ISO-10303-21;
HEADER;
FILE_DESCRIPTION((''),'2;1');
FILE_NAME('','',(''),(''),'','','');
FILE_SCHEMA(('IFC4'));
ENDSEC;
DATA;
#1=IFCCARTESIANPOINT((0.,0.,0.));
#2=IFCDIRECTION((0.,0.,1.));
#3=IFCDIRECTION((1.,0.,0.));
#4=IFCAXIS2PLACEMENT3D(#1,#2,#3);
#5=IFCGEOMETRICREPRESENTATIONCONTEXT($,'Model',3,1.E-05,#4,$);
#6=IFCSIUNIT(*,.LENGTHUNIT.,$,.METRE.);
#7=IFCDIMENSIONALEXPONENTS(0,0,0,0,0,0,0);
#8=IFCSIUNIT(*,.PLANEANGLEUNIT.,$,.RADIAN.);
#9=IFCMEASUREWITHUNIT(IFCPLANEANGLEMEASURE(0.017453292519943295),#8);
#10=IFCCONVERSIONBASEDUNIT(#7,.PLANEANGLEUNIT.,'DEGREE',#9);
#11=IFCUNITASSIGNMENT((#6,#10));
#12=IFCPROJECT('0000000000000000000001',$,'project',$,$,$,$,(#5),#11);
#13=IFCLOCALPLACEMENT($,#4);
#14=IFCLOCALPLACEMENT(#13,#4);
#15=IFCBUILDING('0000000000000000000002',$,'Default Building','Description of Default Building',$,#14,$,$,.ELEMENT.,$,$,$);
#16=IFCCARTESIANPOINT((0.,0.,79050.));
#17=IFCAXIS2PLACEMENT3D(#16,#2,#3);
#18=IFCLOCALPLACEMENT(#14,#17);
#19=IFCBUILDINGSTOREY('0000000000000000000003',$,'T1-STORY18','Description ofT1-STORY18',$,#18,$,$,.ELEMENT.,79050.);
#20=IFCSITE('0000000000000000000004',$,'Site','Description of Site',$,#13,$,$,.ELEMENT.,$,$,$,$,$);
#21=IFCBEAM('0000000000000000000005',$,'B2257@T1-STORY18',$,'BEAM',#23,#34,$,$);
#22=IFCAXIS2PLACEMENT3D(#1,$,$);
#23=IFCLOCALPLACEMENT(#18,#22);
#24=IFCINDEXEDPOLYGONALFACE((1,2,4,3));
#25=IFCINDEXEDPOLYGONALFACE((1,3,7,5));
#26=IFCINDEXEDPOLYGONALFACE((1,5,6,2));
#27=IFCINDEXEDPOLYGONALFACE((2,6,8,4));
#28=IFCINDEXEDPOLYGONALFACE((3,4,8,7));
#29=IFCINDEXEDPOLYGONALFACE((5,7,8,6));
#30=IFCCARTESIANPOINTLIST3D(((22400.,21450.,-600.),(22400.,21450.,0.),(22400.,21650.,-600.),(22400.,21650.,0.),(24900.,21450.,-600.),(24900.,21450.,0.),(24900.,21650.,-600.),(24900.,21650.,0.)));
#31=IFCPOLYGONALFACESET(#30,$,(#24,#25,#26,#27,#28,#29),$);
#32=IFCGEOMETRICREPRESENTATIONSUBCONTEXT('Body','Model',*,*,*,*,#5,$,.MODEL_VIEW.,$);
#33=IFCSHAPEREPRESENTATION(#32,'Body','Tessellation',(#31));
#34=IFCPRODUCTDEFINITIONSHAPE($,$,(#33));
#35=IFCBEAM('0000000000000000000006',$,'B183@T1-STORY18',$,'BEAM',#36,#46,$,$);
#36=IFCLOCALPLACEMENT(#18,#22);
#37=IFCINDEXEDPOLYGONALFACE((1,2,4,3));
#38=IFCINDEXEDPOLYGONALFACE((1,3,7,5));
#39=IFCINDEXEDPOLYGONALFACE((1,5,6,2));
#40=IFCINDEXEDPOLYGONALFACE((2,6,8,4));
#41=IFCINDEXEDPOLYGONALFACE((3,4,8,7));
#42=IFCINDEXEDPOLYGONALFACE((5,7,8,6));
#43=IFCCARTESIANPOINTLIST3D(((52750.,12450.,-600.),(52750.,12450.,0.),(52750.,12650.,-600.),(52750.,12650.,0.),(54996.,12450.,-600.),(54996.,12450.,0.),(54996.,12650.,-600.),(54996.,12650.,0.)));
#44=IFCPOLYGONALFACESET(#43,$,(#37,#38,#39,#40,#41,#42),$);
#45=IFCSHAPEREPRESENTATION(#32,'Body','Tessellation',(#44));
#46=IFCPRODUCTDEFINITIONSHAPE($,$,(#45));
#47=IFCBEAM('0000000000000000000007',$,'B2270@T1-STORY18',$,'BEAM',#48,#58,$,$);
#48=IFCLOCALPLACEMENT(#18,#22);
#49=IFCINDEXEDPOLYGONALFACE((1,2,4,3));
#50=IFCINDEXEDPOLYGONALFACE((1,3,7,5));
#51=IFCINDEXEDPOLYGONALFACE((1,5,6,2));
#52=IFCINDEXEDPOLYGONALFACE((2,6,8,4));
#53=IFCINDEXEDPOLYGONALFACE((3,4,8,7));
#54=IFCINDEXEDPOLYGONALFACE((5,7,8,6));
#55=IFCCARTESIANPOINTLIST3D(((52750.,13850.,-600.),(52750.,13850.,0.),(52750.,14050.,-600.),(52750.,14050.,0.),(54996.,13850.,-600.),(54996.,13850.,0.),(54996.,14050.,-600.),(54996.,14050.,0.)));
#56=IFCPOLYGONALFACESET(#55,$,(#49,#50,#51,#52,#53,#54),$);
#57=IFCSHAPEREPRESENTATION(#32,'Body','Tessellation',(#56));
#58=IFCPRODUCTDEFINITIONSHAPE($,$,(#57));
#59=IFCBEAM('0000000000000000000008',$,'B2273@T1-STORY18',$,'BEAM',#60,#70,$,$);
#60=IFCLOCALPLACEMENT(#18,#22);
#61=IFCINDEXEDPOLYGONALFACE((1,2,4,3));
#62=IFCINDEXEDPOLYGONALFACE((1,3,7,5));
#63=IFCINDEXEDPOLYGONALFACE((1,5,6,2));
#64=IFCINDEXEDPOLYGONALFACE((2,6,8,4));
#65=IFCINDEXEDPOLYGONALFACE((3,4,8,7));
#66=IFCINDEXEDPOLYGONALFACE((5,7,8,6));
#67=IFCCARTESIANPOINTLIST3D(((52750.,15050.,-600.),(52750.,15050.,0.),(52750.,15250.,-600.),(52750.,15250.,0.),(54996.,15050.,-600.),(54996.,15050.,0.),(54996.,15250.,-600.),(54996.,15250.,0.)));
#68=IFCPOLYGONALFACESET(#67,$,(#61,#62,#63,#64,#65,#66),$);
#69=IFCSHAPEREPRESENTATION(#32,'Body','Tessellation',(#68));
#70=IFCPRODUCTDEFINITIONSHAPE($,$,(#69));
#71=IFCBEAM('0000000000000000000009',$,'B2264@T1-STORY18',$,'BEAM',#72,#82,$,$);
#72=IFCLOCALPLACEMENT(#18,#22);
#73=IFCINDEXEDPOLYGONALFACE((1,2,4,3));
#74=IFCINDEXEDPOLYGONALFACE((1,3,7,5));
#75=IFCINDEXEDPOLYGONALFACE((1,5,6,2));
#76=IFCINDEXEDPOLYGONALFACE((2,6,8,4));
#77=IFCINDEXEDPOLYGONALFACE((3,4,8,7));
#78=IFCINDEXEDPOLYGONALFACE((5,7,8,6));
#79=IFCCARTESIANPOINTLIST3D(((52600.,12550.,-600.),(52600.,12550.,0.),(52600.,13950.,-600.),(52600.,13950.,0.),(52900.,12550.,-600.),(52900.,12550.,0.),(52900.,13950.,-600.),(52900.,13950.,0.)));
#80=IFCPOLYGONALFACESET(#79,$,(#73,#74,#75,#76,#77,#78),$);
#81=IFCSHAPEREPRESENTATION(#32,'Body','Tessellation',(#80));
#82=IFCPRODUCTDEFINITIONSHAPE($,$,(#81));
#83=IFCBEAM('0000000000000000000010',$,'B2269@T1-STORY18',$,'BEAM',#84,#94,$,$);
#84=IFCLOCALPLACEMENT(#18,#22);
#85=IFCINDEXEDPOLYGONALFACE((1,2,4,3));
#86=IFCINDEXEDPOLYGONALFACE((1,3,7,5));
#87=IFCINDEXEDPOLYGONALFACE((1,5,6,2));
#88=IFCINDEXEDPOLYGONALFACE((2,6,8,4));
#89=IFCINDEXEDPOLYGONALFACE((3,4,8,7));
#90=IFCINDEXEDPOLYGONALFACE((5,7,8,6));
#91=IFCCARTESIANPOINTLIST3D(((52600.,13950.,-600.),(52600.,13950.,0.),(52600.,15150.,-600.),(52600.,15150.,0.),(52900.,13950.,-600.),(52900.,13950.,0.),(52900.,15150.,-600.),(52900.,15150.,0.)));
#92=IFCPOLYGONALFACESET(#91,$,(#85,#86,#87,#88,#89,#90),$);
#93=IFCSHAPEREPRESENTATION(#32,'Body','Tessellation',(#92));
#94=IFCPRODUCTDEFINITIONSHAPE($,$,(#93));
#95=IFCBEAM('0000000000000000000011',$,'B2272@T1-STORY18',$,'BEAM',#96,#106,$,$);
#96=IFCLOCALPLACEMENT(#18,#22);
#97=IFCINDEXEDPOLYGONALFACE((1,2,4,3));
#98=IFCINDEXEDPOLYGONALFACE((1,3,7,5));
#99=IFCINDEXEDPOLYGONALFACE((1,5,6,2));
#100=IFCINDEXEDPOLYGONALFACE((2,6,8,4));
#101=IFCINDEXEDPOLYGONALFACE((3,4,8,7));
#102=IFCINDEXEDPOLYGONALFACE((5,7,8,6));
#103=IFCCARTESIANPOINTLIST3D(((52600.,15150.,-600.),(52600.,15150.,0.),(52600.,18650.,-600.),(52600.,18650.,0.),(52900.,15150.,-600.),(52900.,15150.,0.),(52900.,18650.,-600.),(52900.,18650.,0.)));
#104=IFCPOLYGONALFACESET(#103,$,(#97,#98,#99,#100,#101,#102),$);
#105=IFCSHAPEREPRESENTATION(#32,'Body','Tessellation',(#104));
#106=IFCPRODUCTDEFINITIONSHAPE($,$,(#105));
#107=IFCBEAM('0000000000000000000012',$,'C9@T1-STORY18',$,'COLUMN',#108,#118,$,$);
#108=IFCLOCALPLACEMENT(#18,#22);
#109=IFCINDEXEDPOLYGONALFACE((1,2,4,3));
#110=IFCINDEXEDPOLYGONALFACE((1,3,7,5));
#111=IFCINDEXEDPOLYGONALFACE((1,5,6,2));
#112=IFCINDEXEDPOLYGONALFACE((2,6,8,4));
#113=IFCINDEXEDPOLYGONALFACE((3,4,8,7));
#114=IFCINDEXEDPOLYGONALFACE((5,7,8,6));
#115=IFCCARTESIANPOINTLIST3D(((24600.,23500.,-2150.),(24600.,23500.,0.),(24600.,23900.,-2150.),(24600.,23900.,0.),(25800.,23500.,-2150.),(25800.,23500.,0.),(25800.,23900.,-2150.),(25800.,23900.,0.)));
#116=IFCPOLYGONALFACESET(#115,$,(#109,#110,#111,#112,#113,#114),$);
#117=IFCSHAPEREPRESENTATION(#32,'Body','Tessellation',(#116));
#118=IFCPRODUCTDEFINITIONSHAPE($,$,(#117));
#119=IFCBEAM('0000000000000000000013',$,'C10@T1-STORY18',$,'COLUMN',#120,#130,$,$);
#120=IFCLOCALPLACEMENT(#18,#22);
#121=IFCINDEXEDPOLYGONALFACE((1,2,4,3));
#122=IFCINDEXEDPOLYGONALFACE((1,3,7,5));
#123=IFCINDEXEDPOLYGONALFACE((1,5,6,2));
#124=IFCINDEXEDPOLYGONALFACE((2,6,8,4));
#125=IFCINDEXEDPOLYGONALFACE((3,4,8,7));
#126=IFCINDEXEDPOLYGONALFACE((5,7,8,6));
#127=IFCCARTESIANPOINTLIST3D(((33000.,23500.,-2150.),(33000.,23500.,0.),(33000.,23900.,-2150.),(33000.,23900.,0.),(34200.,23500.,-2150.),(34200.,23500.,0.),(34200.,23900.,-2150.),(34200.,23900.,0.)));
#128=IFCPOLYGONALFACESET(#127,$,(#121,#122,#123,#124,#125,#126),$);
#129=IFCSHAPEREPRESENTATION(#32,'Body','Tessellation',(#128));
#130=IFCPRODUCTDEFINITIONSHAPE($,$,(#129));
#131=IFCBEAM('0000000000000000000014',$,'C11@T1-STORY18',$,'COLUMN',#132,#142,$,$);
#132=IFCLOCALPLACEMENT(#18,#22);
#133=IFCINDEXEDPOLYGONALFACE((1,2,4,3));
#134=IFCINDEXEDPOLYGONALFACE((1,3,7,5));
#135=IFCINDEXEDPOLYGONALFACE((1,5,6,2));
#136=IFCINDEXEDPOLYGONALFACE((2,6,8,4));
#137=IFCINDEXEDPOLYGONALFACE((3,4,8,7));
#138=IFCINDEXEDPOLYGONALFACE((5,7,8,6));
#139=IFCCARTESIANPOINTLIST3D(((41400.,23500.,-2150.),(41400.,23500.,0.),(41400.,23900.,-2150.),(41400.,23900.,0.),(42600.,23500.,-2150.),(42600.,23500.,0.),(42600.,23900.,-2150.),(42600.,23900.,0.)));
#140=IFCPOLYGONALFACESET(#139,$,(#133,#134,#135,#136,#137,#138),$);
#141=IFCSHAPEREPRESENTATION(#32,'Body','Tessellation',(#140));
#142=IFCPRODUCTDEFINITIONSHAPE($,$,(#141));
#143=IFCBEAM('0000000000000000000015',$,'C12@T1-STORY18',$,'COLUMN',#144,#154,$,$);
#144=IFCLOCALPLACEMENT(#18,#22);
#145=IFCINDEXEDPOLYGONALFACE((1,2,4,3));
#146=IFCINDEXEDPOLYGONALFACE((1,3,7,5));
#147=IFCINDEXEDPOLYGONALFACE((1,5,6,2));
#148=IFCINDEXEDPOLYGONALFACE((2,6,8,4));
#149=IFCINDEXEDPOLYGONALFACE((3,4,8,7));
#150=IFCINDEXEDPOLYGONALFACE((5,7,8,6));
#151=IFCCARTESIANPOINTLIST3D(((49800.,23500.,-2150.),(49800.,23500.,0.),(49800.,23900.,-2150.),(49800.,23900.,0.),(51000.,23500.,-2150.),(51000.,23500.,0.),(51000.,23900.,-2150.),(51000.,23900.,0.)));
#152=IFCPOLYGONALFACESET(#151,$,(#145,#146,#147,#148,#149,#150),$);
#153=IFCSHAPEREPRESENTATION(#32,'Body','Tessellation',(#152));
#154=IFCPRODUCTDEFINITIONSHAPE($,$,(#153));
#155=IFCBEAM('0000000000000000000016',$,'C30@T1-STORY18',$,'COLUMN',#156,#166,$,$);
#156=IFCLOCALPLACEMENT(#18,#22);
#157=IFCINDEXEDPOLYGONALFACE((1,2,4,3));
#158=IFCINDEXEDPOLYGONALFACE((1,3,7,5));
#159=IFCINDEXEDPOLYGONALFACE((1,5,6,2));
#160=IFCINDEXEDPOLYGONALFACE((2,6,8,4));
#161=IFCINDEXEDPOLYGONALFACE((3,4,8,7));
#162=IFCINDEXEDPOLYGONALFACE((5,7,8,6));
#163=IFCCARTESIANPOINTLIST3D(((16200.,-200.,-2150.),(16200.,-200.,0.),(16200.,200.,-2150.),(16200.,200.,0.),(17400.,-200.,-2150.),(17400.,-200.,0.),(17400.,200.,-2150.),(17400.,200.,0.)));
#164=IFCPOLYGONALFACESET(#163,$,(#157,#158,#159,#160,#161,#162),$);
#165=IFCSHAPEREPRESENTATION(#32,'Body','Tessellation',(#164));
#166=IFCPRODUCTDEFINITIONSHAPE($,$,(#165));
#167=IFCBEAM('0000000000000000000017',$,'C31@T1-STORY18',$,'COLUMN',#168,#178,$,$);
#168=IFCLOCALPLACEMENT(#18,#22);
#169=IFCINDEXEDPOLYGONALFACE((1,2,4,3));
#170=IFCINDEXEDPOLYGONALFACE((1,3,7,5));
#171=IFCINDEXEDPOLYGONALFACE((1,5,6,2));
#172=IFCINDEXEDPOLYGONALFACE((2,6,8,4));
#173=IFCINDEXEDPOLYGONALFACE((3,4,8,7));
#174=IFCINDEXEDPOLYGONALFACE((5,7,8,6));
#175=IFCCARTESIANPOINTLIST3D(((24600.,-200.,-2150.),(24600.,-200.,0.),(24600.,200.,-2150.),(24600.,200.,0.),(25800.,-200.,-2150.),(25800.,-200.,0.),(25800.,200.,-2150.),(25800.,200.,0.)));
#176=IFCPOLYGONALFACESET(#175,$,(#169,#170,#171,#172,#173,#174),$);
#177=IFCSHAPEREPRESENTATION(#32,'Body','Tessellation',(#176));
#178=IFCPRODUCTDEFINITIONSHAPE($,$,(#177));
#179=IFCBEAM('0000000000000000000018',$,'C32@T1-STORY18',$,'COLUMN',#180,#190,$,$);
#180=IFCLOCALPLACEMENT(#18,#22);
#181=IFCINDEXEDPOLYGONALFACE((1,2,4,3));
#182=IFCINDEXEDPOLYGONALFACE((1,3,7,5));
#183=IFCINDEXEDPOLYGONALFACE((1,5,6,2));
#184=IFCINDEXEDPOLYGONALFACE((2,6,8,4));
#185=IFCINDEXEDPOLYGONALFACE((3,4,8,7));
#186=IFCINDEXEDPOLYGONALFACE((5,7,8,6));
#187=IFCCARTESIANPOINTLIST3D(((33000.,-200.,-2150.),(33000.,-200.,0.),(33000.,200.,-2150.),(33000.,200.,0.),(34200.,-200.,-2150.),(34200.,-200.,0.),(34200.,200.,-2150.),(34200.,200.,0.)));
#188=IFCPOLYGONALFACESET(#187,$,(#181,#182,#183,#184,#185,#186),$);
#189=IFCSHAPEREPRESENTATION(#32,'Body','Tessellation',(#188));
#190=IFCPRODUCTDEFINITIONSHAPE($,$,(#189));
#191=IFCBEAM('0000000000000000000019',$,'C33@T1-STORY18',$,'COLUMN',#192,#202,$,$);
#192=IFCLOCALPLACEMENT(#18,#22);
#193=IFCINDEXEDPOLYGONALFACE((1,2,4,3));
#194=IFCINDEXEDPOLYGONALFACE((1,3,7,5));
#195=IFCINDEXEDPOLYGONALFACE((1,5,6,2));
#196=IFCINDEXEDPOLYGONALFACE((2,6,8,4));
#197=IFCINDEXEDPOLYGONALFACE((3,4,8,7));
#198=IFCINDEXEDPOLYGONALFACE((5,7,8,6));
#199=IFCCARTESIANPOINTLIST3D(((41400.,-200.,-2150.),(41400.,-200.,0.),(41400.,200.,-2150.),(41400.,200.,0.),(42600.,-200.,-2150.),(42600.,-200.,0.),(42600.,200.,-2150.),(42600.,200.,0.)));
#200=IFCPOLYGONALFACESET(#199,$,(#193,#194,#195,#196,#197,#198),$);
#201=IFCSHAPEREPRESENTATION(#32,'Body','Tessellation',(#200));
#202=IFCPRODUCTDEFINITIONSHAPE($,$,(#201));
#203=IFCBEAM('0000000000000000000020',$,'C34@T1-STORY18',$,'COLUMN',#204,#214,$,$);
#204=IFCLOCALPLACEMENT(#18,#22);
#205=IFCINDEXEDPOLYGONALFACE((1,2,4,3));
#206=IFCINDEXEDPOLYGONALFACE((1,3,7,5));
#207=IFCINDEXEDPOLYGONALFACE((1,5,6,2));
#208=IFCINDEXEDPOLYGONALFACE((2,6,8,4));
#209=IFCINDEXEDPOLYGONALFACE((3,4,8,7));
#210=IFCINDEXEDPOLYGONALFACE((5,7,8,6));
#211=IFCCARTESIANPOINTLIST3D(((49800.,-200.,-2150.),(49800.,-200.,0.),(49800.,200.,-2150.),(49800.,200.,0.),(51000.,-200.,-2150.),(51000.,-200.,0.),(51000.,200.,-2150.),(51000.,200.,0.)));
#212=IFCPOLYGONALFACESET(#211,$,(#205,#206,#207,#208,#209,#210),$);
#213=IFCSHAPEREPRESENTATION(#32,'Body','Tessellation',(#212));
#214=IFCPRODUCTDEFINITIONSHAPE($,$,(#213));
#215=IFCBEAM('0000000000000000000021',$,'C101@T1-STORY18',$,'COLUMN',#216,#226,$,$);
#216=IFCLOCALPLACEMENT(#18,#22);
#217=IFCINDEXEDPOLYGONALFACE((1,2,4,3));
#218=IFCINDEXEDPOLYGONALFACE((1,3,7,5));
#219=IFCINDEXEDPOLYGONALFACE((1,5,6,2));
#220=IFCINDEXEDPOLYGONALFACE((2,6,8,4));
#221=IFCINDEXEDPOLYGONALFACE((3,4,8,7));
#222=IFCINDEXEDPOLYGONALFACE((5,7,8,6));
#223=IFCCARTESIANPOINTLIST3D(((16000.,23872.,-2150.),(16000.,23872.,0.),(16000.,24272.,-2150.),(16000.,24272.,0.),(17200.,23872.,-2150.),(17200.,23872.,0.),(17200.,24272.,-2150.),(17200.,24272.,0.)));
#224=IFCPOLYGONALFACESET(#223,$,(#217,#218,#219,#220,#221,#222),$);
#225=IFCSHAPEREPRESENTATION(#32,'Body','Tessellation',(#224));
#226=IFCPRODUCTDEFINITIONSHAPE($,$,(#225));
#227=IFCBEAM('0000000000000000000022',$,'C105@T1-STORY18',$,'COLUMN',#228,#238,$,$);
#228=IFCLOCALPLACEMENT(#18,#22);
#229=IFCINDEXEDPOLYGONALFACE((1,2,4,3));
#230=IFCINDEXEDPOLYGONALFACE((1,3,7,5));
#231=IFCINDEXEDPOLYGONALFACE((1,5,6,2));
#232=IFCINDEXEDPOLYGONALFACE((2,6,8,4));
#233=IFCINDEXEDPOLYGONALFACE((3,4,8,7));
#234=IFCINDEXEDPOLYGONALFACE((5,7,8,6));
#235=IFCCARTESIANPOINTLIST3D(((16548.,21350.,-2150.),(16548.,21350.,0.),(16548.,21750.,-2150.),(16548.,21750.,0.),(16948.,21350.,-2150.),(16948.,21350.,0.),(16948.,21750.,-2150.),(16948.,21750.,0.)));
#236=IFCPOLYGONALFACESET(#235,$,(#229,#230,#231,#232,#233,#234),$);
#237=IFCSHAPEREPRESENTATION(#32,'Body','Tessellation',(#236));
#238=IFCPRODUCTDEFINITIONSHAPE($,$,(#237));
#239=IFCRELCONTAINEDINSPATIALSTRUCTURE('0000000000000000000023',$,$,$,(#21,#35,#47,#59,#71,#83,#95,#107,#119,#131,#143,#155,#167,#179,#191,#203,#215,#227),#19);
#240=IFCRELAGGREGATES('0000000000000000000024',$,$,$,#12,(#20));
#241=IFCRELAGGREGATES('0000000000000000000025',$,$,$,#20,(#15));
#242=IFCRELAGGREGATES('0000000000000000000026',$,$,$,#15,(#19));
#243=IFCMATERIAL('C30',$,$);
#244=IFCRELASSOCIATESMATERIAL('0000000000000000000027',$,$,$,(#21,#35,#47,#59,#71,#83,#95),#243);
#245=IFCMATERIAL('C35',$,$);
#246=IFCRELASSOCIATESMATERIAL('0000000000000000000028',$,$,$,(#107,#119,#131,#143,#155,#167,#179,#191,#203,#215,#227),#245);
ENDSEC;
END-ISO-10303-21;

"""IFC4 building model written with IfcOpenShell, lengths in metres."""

from ifc_helpers import new_model, entity, si_unit, converted_unit, frame, origin_with_axes, place, context, subcontext, project, spatial, rectangle, extrude, material, element, save


model = new_model("IFC4")

# Units and contexts
model_context = context("Model", 3, precision=1e-05, world=origin_with_axes())
body_context = subcontext(model_context, "Body", "Model", "MODEL_VIEW")
ifc_project = project(units=[si_unit("LENGTHUNIT", "METRE"), converted_unit("PLANEANGLEUNIT", "DEGREE", entity("IfcPlaneAngleMeasure", 0.017453292519943295), si_unit("PLANEANGLEUNIT", "RADIAN"), dimensions=[0, 0, 0, 0, 0, 0, 0])], contexts=[model_context])

# Site, building, storey
site_placement = place(None, origin_with_axes())
site = spatial("IfcSite", under=ifc_project, at=site_placement, Name="Site", Description="Description of Site", CompositionType="ELEMENT")
building_placement = place(site_placement, origin_with_axes())
building = spatial("IfcBuilding", under=site, at=building_placement, Name="Default Building", Description="Description of Default Building", CompositionType="ELEMENT")
storey_placement = place(building_placement, frame((0.0, 0.0, 79050.0), z_axis=(0.0, 0.0, 1.0), x_axis=(1.0, 0.0, 0.0)))
storey = spatial("IfcBuildingStorey", under=building, at=storey_placement, Name="T1-STORY18", Description="Description ofT1-STORY18", CompositionType="ELEMENT", Elevation=79050.0)

# Beams
ifc_material_1 = material(Name="C30")
for number, where, z_axis, x_axis, name in (
    (1, (22400.0, 21550.0, -300.0), (1.0, 0.0, 0.0), (0.0, 1.0, 0.0), "B2257@T1-STORY18"),
):
    element("IfcBeam", number, at=place(storey_placement, frame(where, z_axis=z_axis, x_axis=x_axis)), inside=storey, material=ifc_material_1, Name=name, ObjectType="BEAM", context=body_context, shape_type="SweptSolid", body=[
        extrude(rectangle(XDim=200.0, YDim=600.0), origin_with_axes(), (0.0, 0.0, 1.0), 2500.0),
    ])
for number, where, z_axis, x_axis, name in (
    (2, (52750.0, 12550.0, -300.0), (1.0, 0.0, 0.0), (0.0, 1.0, 0.0), "B183@T1-STORY18"),
    (3, (52750.0, 13950.0, -300.0), (1.0, 0.0, 0.0), (0.0, 1.0, 0.0), "B2270@T1-STORY18"),
    (4, (52750.0, 15150.0, -300.0), (1.0, 0.0, 0.0), (0.0, 1.0, 0.0), "B2273@T1-STORY18"),
):
    element("IfcBeam", number, at=place(storey_placement, frame(where, z_axis=z_axis, x_axis=x_axis)), inside=storey, material=ifc_material_1, Name=name, ObjectType="BEAM", context=body_context, shape_type="SweptSolid", body=[
        extrude(rectangle(XDim=200.0, YDim=600.0), origin_with_axes(), (0.0, 0.0, 1.0), 2246.0),
    ])
beam_1_placement = place(storey_placement, frame((52750.0, 12550.0, -300.0), z_axis=(0.0, 1.0, 0.0), x_axis=(-1.0, 0.0, 0.0)))
element("IfcBeam", 5, at=beam_1_placement, inside=storey, material=ifc_material_1, Name="B2264@T1-STORY18", ObjectType="BEAM", context=body_context, shape_type="SweptSolid", body=[
    extrude(rectangle(XDim=300.0, YDim=600.0), origin_with_axes(), (0.0, 0.0, 1.0), 1400.0),
])
beam_2_placement = place(storey_placement, frame((52750.0, 13950.0, -300.0), z_axis=(0.0, 1.0, 0.0), x_axis=(-1.0, 0.0, 0.0)))
element("IfcBeam", 6, at=beam_2_placement, inside=storey, material=ifc_material_1, Name="B2269@T1-STORY18", ObjectType="BEAM", context=body_context, shape_type="SweptSolid", body=[
    extrude(rectangle(XDim=300.0, YDim=600.0), origin_with_axes(), (0.0, 0.0, 1.0), 1200.0),
])
beam_3_placement = place(storey_placement, frame((52750.0, 15150.0, -300.0), z_axis=(0.0, 1.0, 0.0), x_axis=(-1.0, 0.0, 0.0)))
element("IfcBeam", 7, at=beam_3_placement, inside=storey, material=ifc_material_1, Name="B2272@T1-STORY18", ObjectType="BEAM", context=body_context, shape_type="SweptSolid", body=[
    extrude(rectangle(XDim=300.0, YDim=600.0), origin_with_axes(), (0.0, 0.0, 1.0), 3500.0),
])
ifc_material_2 = material(Name="C35")
for number, where, z_axis, x_axis, name in (
    (8, (25200.0, 23700.0, -2150.0), (0.0, 0.0, 1.0), (0.0, -1.0, 0.0), "C9@T1-STORY18"),
    (9, (33600.0, 23700.0, -2150.0), (0.0, 0.0, 1.0), (0.0, -1.0, 0.0), "C10@T1-STORY18"),
    (10, (42000.0, 23700.0, -2150.0), (0.0, 0.0, 1.0), (0.0, -1.0, 0.0), "C11@T1-STORY18"),
    (11, (50400.0, 23700.0, -2150.0), (0.0, 0.0, 1.0), (0.0, -1.0, 0.0), "C12@T1-STORY18"),
    (12, (16800.0, 0.0, -2150.0), (0.0, 0.0, 1.0), (0.0, -1.0, 0.0), "C30@T1-STORY18"),
    (13, (25200.0, 0.0, -2150.0), (0.0, 0.0, 1.0), (0.0, -1.0, 0.0), "C31@T1-STORY18"),
    (14, (33600.0, 0.0, -2150.0), (0.0, 0.0, 1.0), (0.0, -1.0, 0.0), "C32@T1-STORY18"),
    (15, (42000.0, 0.0, -2150.0), (0.0, 0.0, 1.0), (0.0, -1.0, 0.0), "C33@T1-STORY18"),
    (16, (50400.0, 0.0, -2150.0), (0.0, 0.0, 1.0), (0.0, -1.0, 0.0), "C34@T1-STORY18"),
    (17, (16600.0, 24072.0, -2150.0), (0.0, 0.0, 1.0), (0.0, -1.0, 0.0), "C101@T1-STORY18"),
):
    element("IfcBeam", number, at=place(storey_placement, frame(where, z_axis=z_axis, x_axis=x_axis)), inside=storey, material=ifc_material_2, Name=name, ObjectType="COLUMN", context=body_context, shape_type="SweptSolid", body=[
        extrude(rectangle(XDim=400.0, YDim=1200.0), origin_with_axes(), (0.0, 0.0, 1.0), 2150.0),
    ])
for number, where, z_axis, x_axis, name in (
    (18, (16748.0, 21550.0, -2150.0), (0.0, 0.0, 1.0), (-1.0, 0.0, 0.0), "C105@T1-STORY18"),
):
    element("IfcBeam", number, at=place(storey_placement, frame(where, z_axis=z_axis, x_axis=x_axis)), inside=storey, material=ifc_material_2, Name=name, ObjectType="COLUMN", context=body_context, shape_type="SweptSolid", body=[
        extrude(rectangle(XDim=400.0, YDim=400.0), origin_with_axes(), (0.0, 0.0, 1.0), 2150.0),
    ])

save(model, "model.ifc")
